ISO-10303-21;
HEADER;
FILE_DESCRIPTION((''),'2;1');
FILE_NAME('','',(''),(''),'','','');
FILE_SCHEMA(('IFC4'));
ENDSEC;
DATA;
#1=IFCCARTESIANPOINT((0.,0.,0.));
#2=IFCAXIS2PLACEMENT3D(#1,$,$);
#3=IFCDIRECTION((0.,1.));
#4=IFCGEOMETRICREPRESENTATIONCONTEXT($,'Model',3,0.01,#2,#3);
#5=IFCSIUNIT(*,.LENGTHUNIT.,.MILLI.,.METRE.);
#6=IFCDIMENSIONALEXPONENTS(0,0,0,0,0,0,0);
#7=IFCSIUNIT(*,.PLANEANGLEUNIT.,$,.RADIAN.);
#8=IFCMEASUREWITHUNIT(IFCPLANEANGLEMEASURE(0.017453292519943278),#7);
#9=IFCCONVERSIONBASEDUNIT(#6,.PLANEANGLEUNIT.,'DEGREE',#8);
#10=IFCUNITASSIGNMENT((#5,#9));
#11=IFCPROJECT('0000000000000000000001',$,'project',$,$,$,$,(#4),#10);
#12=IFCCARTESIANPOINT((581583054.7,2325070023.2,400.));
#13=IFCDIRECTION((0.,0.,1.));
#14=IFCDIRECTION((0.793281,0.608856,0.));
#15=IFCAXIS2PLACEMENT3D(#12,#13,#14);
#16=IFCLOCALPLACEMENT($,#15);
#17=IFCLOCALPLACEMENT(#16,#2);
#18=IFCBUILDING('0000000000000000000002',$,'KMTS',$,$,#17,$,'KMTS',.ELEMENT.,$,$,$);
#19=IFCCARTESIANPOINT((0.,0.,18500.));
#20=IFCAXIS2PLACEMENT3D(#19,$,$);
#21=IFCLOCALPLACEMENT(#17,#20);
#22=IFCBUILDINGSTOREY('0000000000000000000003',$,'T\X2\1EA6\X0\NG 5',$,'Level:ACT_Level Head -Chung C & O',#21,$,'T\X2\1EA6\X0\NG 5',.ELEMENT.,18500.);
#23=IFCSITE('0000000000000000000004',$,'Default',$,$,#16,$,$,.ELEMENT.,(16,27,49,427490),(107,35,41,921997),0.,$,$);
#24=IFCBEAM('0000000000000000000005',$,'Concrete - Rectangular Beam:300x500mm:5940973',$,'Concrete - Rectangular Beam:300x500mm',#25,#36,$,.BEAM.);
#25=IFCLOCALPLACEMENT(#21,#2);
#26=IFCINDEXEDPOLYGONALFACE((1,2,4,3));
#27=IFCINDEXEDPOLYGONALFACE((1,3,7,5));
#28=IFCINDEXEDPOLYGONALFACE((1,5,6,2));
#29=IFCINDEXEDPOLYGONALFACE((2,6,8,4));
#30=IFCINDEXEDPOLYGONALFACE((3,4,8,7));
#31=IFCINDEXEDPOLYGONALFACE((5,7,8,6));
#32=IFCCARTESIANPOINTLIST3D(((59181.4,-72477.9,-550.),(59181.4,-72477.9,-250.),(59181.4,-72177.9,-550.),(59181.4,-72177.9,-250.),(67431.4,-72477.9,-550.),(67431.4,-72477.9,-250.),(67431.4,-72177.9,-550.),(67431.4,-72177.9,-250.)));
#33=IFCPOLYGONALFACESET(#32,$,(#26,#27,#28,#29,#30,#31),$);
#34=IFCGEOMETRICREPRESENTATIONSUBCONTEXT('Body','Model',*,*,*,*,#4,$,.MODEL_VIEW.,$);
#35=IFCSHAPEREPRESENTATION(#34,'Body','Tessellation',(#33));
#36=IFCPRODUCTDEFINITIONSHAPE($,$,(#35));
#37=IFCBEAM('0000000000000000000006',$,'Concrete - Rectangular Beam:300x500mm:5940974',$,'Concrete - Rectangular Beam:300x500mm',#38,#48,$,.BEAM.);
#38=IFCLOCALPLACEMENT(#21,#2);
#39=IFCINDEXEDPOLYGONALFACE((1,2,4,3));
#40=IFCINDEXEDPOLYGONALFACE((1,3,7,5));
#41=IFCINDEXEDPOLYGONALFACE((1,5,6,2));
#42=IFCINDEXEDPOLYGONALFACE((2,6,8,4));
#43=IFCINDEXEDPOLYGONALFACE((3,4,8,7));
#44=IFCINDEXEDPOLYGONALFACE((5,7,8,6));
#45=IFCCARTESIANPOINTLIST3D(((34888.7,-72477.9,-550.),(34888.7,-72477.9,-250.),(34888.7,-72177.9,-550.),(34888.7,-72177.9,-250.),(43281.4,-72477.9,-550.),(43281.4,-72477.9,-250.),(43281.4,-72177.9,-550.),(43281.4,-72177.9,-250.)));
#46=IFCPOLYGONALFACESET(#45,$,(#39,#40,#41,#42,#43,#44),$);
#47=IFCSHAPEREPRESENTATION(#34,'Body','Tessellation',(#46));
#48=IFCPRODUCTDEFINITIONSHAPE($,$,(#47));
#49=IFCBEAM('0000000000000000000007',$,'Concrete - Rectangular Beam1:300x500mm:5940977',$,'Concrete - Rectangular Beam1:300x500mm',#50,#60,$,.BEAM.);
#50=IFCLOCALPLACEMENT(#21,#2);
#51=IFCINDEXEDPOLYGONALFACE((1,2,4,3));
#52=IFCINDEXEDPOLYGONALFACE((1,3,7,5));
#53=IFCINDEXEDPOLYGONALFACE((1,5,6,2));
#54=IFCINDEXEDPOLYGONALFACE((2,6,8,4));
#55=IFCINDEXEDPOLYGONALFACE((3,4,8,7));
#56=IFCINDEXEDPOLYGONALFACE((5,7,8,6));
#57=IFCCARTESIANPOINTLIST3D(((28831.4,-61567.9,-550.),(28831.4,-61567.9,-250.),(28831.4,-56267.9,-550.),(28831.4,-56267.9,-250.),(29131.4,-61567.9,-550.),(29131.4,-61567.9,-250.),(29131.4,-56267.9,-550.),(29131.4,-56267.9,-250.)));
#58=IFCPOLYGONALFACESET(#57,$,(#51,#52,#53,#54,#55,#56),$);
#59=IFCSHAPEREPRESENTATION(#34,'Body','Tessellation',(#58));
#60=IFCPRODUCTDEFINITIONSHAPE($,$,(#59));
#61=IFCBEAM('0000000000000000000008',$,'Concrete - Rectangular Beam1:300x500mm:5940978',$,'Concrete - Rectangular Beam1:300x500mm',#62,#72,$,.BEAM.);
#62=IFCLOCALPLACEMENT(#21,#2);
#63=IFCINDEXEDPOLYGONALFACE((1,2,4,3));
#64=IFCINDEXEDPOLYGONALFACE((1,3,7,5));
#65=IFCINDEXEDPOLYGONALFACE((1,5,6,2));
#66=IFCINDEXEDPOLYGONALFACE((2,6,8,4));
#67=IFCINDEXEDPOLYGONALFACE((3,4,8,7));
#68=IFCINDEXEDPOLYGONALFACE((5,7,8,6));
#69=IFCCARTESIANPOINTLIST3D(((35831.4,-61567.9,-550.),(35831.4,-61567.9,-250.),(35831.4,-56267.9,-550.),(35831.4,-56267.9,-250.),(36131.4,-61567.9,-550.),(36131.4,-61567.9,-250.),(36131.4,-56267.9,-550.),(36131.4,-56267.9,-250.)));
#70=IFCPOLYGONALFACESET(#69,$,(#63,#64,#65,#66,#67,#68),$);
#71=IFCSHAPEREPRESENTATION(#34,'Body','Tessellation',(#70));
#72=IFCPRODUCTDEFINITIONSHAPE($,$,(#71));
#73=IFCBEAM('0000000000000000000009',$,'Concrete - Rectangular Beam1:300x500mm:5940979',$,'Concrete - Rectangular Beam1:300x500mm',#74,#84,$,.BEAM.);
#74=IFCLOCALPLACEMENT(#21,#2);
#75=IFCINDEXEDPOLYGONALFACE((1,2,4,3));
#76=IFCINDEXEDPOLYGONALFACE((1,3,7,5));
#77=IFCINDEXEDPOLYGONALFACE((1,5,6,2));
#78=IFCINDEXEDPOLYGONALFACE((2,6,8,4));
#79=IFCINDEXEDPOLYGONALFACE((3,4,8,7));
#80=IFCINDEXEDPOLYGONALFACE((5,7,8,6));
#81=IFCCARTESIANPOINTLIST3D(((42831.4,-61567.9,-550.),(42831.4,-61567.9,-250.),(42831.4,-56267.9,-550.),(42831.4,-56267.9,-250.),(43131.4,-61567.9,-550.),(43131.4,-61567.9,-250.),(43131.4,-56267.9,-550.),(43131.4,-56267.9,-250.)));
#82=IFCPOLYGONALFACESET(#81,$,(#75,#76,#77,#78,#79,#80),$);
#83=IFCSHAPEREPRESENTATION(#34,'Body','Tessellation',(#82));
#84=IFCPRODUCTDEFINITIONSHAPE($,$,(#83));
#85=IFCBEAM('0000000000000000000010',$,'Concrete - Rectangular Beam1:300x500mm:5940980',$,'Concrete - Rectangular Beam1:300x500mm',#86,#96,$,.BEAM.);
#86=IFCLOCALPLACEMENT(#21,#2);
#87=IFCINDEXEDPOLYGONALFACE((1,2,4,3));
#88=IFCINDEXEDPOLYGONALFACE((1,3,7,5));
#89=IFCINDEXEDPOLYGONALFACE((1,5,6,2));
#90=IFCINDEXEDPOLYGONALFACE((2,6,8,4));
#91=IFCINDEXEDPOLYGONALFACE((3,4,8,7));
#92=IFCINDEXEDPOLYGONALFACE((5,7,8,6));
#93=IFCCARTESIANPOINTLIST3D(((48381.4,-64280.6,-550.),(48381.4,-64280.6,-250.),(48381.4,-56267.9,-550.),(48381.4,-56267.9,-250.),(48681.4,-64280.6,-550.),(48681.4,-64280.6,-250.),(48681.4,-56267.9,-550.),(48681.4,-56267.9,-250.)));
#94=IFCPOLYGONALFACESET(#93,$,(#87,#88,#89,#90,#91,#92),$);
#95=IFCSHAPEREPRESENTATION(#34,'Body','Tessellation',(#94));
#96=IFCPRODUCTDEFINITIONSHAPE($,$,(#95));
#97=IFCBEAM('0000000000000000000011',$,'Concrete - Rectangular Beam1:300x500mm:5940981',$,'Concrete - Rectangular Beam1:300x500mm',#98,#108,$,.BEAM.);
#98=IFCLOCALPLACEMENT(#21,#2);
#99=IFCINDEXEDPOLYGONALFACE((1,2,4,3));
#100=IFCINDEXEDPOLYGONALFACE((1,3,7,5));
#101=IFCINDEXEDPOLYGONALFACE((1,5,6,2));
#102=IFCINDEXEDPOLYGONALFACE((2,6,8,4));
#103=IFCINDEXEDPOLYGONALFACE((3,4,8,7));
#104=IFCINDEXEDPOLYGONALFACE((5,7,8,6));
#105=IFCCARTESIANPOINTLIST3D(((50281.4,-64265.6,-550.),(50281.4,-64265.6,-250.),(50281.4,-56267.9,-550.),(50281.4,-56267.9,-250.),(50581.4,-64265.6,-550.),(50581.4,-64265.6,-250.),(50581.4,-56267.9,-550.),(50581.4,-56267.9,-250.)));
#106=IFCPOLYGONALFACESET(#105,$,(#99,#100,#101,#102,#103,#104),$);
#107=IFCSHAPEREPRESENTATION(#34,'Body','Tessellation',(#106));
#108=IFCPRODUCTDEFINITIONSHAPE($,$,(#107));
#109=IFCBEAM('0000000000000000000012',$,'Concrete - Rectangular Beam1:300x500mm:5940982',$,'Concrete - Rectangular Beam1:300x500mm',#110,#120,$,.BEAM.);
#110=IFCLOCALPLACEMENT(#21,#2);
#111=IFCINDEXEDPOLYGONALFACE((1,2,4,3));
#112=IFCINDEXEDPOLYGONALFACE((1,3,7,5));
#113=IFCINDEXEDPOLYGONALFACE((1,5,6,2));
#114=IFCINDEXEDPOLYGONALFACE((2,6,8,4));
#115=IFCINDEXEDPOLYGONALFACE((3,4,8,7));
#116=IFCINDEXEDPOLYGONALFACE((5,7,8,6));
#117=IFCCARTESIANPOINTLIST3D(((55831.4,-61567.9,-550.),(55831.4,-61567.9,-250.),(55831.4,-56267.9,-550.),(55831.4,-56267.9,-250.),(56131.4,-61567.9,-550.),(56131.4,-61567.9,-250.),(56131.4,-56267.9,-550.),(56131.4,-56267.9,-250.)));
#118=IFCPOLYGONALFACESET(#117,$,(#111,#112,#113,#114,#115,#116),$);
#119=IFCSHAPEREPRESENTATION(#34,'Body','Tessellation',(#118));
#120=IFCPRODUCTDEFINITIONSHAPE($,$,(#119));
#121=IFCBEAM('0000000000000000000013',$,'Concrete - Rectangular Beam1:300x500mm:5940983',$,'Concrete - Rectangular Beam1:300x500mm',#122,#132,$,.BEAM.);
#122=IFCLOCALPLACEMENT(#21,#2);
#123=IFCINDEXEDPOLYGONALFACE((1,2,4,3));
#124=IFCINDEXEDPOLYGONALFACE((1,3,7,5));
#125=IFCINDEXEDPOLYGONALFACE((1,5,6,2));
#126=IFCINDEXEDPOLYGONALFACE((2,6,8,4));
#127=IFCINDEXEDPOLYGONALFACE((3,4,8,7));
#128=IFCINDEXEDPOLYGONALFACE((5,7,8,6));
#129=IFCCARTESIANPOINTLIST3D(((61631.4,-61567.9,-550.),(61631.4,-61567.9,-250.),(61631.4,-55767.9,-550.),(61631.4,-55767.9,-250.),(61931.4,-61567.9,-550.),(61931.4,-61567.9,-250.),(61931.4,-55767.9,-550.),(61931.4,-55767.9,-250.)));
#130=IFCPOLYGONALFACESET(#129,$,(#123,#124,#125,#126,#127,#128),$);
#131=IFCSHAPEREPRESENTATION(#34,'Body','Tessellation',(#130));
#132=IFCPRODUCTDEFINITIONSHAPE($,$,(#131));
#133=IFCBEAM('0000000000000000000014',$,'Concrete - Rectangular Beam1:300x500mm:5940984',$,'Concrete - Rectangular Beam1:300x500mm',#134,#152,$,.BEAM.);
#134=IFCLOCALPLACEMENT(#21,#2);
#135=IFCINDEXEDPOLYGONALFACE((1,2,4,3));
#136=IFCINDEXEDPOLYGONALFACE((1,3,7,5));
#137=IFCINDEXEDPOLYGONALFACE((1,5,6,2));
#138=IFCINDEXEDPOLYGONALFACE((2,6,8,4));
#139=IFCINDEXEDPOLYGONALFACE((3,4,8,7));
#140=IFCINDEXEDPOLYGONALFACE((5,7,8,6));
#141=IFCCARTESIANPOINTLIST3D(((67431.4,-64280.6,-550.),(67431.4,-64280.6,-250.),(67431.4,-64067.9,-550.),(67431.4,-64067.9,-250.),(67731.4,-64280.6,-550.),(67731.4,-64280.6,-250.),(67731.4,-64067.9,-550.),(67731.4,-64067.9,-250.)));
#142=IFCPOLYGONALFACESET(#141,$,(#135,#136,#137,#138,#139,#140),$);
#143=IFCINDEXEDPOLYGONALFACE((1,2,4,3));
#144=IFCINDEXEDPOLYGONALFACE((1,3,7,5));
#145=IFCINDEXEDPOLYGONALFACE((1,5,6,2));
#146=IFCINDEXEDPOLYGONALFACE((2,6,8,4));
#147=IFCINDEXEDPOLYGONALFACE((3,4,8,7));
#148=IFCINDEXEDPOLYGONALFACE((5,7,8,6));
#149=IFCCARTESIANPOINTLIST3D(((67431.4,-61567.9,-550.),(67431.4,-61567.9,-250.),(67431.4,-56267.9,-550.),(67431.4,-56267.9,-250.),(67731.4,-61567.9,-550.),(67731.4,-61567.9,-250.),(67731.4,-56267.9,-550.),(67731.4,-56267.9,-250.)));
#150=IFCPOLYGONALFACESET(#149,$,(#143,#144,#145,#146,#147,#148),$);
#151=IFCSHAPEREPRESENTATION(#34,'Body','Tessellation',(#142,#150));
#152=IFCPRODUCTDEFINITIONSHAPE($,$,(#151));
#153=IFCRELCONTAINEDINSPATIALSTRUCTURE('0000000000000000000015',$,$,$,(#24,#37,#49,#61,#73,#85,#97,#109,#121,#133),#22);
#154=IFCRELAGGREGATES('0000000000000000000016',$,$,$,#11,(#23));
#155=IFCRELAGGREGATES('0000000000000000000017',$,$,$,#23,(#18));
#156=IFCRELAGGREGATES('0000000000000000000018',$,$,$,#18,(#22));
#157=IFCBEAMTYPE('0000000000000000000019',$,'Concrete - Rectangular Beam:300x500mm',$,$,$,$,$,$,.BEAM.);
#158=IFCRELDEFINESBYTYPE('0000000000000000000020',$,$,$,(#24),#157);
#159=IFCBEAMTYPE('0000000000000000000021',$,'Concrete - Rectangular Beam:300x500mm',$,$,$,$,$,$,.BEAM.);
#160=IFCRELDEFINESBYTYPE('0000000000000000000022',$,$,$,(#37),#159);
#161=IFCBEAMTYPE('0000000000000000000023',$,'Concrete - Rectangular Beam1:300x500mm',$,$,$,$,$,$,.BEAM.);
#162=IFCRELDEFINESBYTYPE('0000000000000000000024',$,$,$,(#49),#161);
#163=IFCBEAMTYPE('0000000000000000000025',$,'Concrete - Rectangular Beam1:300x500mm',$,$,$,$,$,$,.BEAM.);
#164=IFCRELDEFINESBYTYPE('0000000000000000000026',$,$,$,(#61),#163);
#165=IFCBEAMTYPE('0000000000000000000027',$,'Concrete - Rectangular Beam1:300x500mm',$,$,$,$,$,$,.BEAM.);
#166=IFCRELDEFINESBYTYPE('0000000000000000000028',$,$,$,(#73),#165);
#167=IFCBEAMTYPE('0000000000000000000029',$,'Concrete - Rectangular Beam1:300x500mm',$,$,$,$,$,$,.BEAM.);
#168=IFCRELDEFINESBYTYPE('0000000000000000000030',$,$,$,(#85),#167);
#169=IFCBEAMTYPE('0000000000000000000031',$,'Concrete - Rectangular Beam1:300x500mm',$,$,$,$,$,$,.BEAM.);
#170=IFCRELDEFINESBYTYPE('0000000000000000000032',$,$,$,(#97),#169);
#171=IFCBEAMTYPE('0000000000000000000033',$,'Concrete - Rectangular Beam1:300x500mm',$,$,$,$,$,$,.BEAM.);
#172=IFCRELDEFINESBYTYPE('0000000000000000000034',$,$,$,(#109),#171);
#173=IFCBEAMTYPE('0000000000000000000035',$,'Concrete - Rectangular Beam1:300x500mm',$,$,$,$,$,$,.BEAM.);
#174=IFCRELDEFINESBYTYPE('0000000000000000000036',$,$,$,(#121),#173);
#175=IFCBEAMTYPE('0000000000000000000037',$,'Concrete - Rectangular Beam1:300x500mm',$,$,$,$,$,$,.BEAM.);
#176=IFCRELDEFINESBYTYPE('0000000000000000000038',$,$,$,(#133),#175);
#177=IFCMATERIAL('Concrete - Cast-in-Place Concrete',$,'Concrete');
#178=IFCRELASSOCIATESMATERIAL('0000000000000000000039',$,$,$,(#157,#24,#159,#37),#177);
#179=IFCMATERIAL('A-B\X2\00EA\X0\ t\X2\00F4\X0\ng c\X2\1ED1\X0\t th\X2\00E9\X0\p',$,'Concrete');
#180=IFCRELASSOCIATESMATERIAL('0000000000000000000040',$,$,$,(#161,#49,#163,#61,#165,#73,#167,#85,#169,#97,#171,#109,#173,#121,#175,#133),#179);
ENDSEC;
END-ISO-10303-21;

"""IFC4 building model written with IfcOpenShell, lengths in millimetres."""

from ifc_helpers import new_model, entity, si_unit, converted_unit, direction, frame, origin, place, context, subcontext, project, spatial, indexed_curve, outline, extrude, source, transform, mapped, material, type_object, type_shapes, element, save


model = new_model("IFC4")

# Units and contexts
model_context = context("Model", 3, precision=0.01, world=origin(), true_north=direction((0.0, 1.0)))
body_context = subcontext(model_context, "Body", "Model", "MODEL_VIEW")
ifc_project = project(units=[si_unit("LENGTHUNIT", "METRE", prefix="MILLI"), converted_unit("PLANEANGLEUNIT", "DEGREE", entity("IfcPlaneAngleMeasure", 0.017453292519943278), si_unit("PLANEANGLEUNIT", "RADIAN"), dimensions=[0, 0, 0, 0, 0, 0, 0])], contexts=[model_context])

# Site, building, storey
site_placement = place(None, frame((581583054.7, 2325070023.2, 400.0), z_axis=(0.0, 0.0, 1.0), x_axis=(0.793281, 0.608856, 0.0)))
site = spatial("IfcSite", under=ifc_project, at=site_placement, Name="Default", CompositionType="ELEMENT", RefLatitude=(16, 27, 49, 427490), RefLongitude=(107, 35, 41, 921997), RefElevation=0.0)
building_placement = place(site_placement, origin())
building = spatial("IfcBuilding", under=site, at=building_placement, Name="KMTS", LongName="KMTS", CompositionType="ELEMENT")
storey_placement = place(building_placement, frame((0.0, 0.0, 18500.0)))
storey = spatial("IfcBuildingStorey", under=building, at=storey_placement, Name="TẦNG 5", ObjectType="Level:ACT_Level Head -Chung C & O", LongName="TẦNG 5", CompositionType="ELEMENT", Elevation=18500.0)

# Beams
ifc_material_1 = material(Name="Concrete - Cast-in-Place Concrete", Category="Concrete")
beam_type_1 = type_object("IfcBeamType", Name="Concrete - Rectangular Beam:300x500mm", PredefinedType="BEAM", material=ifc_material_1)
shared_shape_1 = source(origin(), body_context, "Body", "SweptSolid", [
    extrude(outline(indexed_curve([(-150.0, -150.0), (150.0, -150.0), (150.0, 150.0), (-150.0, 150.0), (-150.0, -150.0)], self_intersect=False)), frame((59181.4, -72327.9, 18100.0), z_axis=(1.0, 0.0, 0.0), x_axis=(0.0, 0.0, -1.0)), (0.0, 0.0, 1.0), 8250.0),
])
type_shapes(beam_type_1, [shared_shape_1])
beam_1_placement = place(storey_placement, frame((0.0, 0.0, -18500.0)))
element("IfcBeam", 1, at=beam_1_placement, inside=storey, type_object=beam_type_1, material=ifc_material_1, Name="Concrete - Rectangular Beam:300x500mm:5940973", ObjectType="Concrete - Rectangular Beam:300x500mm", PredefinedType="BEAM", context=body_context, shape_type="MappedRepresentation", body=[
    mapped(shared_shape_1, transform((0.0, 0.0, 0.0), scale=1.0)),
])
beam_type_2 = type_object("IfcBeamType", Name="Concrete - Rectangular Beam:300x500mm", PredefinedType="BEAM", material=ifc_material_1)
shared_shape_2 = source(origin(), body_context, "Body", "SweptSolid", [
    extrude(outline(indexed_curve([(-150.0, -150.0), (150.0, -150.0), (150.0, 150.0), (-150.0, 150.0), (-150.0, -150.0)], self_intersect=False)), frame((34888.7, -72327.9, 18100.0), z_axis=(1.0, 0.0, 0.0), x_axis=(0.0, 0.0, -1.0)), (0.0, 0.0, 1.0), 8392.7),
])
type_shapes(beam_type_2, [shared_shape_2])
beam_2_placement = place(storey_placement, frame((0.0, 0.0, -18500.0)))
element("IfcBeam", 2, at=beam_2_placement, inside=storey, type_object=beam_type_2, material=ifc_material_1, Name="Concrete - Rectangular Beam:300x500mm:5940974", ObjectType="Concrete - Rectangular Beam:300x500mm", PredefinedType="BEAM", context=body_context, shape_type="MappedRepresentation", body=[
    mapped(shared_shape_2, transform((0.0, 0.0, 0.0), scale=1.0)),
])
ifc_material_2 = material(Name="A-Bê tông cốt thép", Category="Concrete")
beam_type_3 = type_object("IfcBeamType", Name="Concrete - Rectangular Beam1:300x500mm", PredefinedType="BEAM", material=ifc_material_2)
shared_shape_3 = source(origin(), body_context, "Body", "SweptSolid", [
    extrude(outline(indexed_curve([(-150.0, -150.0), (150.0, -150.0), (150.0, 150.0), (-150.0, 150.0), (-150.0, -150.0)], self_intersect=False)), frame((28981.4, -56267.9, 18100.0), z_axis=(0.0, -1.0, 0.0), x_axis=(-1.0, 0.0, 0.0)), (0.0, 0.0, 1.0), 5300.0),
])
type_shapes(beam_type_3, [shared_shape_3])
beam_3_placement = place(storey_placement, frame((0.0, 0.0, -18500.0)))
element("IfcBeam", 3, at=beam_3_placement, inside=storey, type_object=beam_type_3, material=ifc_material_2, Name="Concrete - Rectangular Beam1:300x500mm:5940977", ObjectType="Concrete - Rectangular Beam1:300x500mm", PredefinedType="BEAM", context=body_context, shape_type="MappedRepresentation", body=[
    mapped(shared_shape_3, transform((0.0, 0.0, 0.0), scale=1.0)),
])
beam_type_4 = type_object("IfcBeamType", Name="Concrete - Rectangular Beam1:300x500mm", PredefinedType="BEAM", material=ifc_material_2)
shared_shape_4 = source(origin(), body_context, "Body", "SweptSolid", [
    extrude(outline(indexed_curve([(-150.0, -150.0), (150.0, -150.0), (150.0, 150.0), (-150.0, 150.0), (-150.0, -150.0)], self_intersect=False)), frame((35981.4, -56267.9, 18100.0), z_axis=(0.0, -1.0, 0.0), x_axis=(-1.0, 0.0, 0.0)), (0.0, 0.0, 1.0), 5300.0),
])
type_shapes(beam_type_4, [shared_shape_4])
beam_4_placement = place(storey_placement, frame((0.0, 0.0, -18500.0)))
element("IfcBeam", 4, at=beam_4_placement, inside=storey, type_object=beam_type_4, material=ifc_material_2, Name="Concrete - Rectangular Beam1:300x500mm:5940978", ObjectType="Concrete - Rectangular Beam1:300x500mm", PredefinedType="BEAM", context=body_context, shape_type="MappedRepresentation", body=[
    mapped(shared_shape_4, transform((0.0, 0.0, 0.0), scale=1.0)),
])
beam_type_5 = type_object("IfcBeamType", Name="Concrete - Rectangular Beam1:300x500mm", PredefinedType="BEAM", material=ifc_material_2)
shared_shape_5 = source(origin(), body_context, "Body", "SweptSolid", [
    extrude(outline(indexed_curve([(-150.0, -150.0), (150.0, -150.0), (150.0, 150.0), (-150.0, 150.0), (-150.0, -150.0)], self_intersect=False)), frame((42981.4, -56267.9, 18100.0), z_axis=(0.0, -1.0, 0.0), x_axis=(-1.0, 0.0, 0.0)), (0.0, 0.0, 1.0), 5300.0),
])
type_shapes(beam_type_5, [shared_shape_5])
beam_5_placement = place(storey_placement, frame((0.0, 0.0, -18500.0)))
element("IfcBeam", 5, at=beam_5_placement, inside=storey, type_object=beam_type_5, material=ifc_material_2, Name="Concrete - Rectangular Beam1:300x500mm:5940979", ObjectType="Concrete - Rectangular Beam1:300x500mm", PredefinedType="BEAM", context=body_context, shape_type="MappedRepresentation", body=[
    mapped(shared_shape_5, transform((0.0, 0.0, 0.0), scale=1.0)),
])
beam_type_6 = type_object("IfcBeamType", Name="Concrete - Rectangular Beam1:300x500mm", PredefinedType="BEAM", material=ifc_material_2)
shared_shape_6 = source(origin(), body_context, "Body", "SweptSolid", [
    extrude(outline(indexed_curve([(-150.0, -150.0), (150.0, -150.0), (150.0, 150.0), (-150.0, 150.0), (-150.0, -150.0)], self_intersect=False)), frame((48531.4, -56267.9, 18100.0), z_axis=(0.0, -1.0, 0.0), x_axis=(-1.0, 0.0, 0.0)), (0.0, 0.0, 1.0), 8012.7),
])
type_shapes(beam_type_6, [shared_shape_6])
beam_6_placement = place(storey_placement, frame((0.0, 0.0, -18500.0)))
element("IfcBeam", 6, at=beam_6_placement, inside=storey, type_object=beam_type_6, material=ifc_material_2, Name="Concrete - Rectangular Beam1:300x500mm:5940980", ObjectType="Concrete - Rectangular Beam1:300x500mm", PredefinedType="BEAM", context=body_context, shape_type="MappedRepresentation", body=[
    mapped(shared_shape_6, transform((0.0, 0.0, 0.0), scale=1.0)),
])
beam_type_7 = type_object("IfcBeamType", Name="Concrete - Rectangular Beam1:300x500mm", PredefinedType="BEAM", material=ifc_material_2)
shared_shape_7 = source(origin(), body_context, "Body", "SweptSolid", [
    extrude(outline(indexed_curve([(-150.0, -150.0), (150.0, -150.0), (150.0, 150.0), (-150.0, 150.0), (-150.0, -150.0)], self_intersect=False)), frame((50431.4, -56267.9, 18100.0), z_axis=(0.0, -1.0, 0.0), x_axis=(-1.0, 0.0, 0.0)), (0.0, 0.0, 1.0), 7997.7),
])
type_shapes(beam_type_7, [shared_shape_7])
beam_7_placement = place(storey_placement, frame((0.0, 0.0, -18500.0)))
element("IfcBeam", 7, at=beam_7_placement, inside=storey, type_object=beam_type_7, material=ifc_material_2, Name="Concrete - Rectangular Beam1:300x500mm:5940981", ObjectType="Concrete - Rectangular Beam1:300x500mm", PredefinedType="BEAM", context=body_context, shape_type="MappedRepresentation", body=[
    mapped(shared_shape_7, transform((0.0, 0.0, 0.0), scale=1.0)),
])
beam_type_8 = type_object("IfcBeamType", Name="Concrete - Rectangular Beam1:300x500mm", PredefinedType="BEAM", material=ifc_material_2)
shared_shape_8 = source(origin(), body_context, "Body", "SweptSolid", [
    extrude(outline(indexed_curve([(-150.0, -150.0), (150.0, -150.0), (150.0, 150.0), (-150.0, 150.0), (-150.0, -150.0)], self_intersect=False)), frame((55981.4, -56267.9, 18100.0), z_axis=(0.0, -1.0, 0.0), x_axis=(-1.0, 0.0, 0.0)), (0.0, 0.0, 1.0), 5300.0),
])
type_shapes(beam_type_8, [shared_shape_8])
beam_8_placement = place(storey_placement, frame((0.0, 0.0, -18500.0)))
element("IfcBeam", 8, at=beam_8_placement, inside=storey, type_object=beam_type_8, material=ifc_material_2, Name="Concrete - Rectangular Beam1:300x500mm:5940982", ObjectType="Concrete - Rectangular Beam1:300x500mm", PredefinedType="BEAM", context=body_context, shape_type="MappedRepresentation", body=[
    mapped(shared_shape_8, transform((0.0, 0.0, 0.0), scale=1.0)),
])
beam_type_9 = type_object("IfcBeamType", Name="Concrete - Rectangular Beam1:300x500mm", PredefinedType="BEAM", material=ifc_material_2)
shared_shape_9 = source(origin(), body_context, "Body", "SweptSolid", [
    extrude(outline(indexed_curve([(-150.0, -150.0), (150.0, -150.0), (150.0, 150.0), (-150.0, 150.0), (-150.0, -150.0)], self_intersect=False)), frame((61781.4, -55767.9, 18100.0), z_axis=(0.0, -1.0, 0.0), x_axis=(-1.0, 0.0, 0.0)), (0.0, 0.0, 1.0), 5800.0),
])
type_shapes(beam_type_9, [shared_shape_9])
beam_9_placement = place(storey_placement, frame((0.0, 0.0, -18500.0)))
element("IfcBeam", 9, at=beam_9_placement, inside=storey, type_object=beam_type_9, material=ifc_material_2, Name="Concrete - Rectangular Beam1:300x500mm:5940983", ObjectType="Concrete - Rectangular Beam1:300x500mm", PredefinedType="BEAM", context=body_context, shape_type="MappedRepresentation", body=[
    mapped(shared_shape_9, transform((0.0, 0.0, 0.0), scale=1.0)),
])
beam_type_10 = type_object("IfcBeamType", Name="Concrete - Rectangular Beam1:300x500mm", PredefinedType="BEAM", material=ifc_material_2)
shared_shape_10 = source(origin(), body_context, "Body", "SweptSolid", [
    extrude(outline(indexed_curve([(-150.0, -150.0), (150.0, -150.0), (150.0, 150.0), (-150.0, 150.0), (-150.0, -150.0)], self_intersect=False)), frame((67581.4, -64067.9, 18100.0), z_axis=(0.0, -1.0, 0.0), x_axis=(-1.0, 0.0, 0.0)), (0.0, 0.0, 1.0), 212.7),
    extrude(outline(indexed_curve([(-150.0, -150.0), (150.0, -150.0), (150.0, 150.0), (-150.0, 150.0), (-150.0, -150.0)], self_intersect=False)), frame((67581.4, -56267.9, 18100.0), z_axis=(0.0, -1.0, 0.0), x_axis=(-1.0, 0.0, 0.0)), (0.0, 0.0, 1.0), 5300.0),
])
type_shapes(beam_type_10, [shared_shape_10])
beam_10_placement = place(storey_placement, frame((0.0, 0.0, -18500.0)))
element("IfcBeam", 10, at=beam_10_placement, inside=storey, type_object=beam_type_10, material=ifc_material_2, Name="Concrete - Rectangular Beam1:300x500mm:5940984", ObjectType="Concrete - Rectangular Beam1:300x500mm", PredefinedType="BEAM", context=body_context, shape_type="MappedRepresentation", body=[
    mapped(shared_shape_10, transform((0.0, 0.0, 0.0), scale=1.0)),
])

save(model, "model.ifc")
